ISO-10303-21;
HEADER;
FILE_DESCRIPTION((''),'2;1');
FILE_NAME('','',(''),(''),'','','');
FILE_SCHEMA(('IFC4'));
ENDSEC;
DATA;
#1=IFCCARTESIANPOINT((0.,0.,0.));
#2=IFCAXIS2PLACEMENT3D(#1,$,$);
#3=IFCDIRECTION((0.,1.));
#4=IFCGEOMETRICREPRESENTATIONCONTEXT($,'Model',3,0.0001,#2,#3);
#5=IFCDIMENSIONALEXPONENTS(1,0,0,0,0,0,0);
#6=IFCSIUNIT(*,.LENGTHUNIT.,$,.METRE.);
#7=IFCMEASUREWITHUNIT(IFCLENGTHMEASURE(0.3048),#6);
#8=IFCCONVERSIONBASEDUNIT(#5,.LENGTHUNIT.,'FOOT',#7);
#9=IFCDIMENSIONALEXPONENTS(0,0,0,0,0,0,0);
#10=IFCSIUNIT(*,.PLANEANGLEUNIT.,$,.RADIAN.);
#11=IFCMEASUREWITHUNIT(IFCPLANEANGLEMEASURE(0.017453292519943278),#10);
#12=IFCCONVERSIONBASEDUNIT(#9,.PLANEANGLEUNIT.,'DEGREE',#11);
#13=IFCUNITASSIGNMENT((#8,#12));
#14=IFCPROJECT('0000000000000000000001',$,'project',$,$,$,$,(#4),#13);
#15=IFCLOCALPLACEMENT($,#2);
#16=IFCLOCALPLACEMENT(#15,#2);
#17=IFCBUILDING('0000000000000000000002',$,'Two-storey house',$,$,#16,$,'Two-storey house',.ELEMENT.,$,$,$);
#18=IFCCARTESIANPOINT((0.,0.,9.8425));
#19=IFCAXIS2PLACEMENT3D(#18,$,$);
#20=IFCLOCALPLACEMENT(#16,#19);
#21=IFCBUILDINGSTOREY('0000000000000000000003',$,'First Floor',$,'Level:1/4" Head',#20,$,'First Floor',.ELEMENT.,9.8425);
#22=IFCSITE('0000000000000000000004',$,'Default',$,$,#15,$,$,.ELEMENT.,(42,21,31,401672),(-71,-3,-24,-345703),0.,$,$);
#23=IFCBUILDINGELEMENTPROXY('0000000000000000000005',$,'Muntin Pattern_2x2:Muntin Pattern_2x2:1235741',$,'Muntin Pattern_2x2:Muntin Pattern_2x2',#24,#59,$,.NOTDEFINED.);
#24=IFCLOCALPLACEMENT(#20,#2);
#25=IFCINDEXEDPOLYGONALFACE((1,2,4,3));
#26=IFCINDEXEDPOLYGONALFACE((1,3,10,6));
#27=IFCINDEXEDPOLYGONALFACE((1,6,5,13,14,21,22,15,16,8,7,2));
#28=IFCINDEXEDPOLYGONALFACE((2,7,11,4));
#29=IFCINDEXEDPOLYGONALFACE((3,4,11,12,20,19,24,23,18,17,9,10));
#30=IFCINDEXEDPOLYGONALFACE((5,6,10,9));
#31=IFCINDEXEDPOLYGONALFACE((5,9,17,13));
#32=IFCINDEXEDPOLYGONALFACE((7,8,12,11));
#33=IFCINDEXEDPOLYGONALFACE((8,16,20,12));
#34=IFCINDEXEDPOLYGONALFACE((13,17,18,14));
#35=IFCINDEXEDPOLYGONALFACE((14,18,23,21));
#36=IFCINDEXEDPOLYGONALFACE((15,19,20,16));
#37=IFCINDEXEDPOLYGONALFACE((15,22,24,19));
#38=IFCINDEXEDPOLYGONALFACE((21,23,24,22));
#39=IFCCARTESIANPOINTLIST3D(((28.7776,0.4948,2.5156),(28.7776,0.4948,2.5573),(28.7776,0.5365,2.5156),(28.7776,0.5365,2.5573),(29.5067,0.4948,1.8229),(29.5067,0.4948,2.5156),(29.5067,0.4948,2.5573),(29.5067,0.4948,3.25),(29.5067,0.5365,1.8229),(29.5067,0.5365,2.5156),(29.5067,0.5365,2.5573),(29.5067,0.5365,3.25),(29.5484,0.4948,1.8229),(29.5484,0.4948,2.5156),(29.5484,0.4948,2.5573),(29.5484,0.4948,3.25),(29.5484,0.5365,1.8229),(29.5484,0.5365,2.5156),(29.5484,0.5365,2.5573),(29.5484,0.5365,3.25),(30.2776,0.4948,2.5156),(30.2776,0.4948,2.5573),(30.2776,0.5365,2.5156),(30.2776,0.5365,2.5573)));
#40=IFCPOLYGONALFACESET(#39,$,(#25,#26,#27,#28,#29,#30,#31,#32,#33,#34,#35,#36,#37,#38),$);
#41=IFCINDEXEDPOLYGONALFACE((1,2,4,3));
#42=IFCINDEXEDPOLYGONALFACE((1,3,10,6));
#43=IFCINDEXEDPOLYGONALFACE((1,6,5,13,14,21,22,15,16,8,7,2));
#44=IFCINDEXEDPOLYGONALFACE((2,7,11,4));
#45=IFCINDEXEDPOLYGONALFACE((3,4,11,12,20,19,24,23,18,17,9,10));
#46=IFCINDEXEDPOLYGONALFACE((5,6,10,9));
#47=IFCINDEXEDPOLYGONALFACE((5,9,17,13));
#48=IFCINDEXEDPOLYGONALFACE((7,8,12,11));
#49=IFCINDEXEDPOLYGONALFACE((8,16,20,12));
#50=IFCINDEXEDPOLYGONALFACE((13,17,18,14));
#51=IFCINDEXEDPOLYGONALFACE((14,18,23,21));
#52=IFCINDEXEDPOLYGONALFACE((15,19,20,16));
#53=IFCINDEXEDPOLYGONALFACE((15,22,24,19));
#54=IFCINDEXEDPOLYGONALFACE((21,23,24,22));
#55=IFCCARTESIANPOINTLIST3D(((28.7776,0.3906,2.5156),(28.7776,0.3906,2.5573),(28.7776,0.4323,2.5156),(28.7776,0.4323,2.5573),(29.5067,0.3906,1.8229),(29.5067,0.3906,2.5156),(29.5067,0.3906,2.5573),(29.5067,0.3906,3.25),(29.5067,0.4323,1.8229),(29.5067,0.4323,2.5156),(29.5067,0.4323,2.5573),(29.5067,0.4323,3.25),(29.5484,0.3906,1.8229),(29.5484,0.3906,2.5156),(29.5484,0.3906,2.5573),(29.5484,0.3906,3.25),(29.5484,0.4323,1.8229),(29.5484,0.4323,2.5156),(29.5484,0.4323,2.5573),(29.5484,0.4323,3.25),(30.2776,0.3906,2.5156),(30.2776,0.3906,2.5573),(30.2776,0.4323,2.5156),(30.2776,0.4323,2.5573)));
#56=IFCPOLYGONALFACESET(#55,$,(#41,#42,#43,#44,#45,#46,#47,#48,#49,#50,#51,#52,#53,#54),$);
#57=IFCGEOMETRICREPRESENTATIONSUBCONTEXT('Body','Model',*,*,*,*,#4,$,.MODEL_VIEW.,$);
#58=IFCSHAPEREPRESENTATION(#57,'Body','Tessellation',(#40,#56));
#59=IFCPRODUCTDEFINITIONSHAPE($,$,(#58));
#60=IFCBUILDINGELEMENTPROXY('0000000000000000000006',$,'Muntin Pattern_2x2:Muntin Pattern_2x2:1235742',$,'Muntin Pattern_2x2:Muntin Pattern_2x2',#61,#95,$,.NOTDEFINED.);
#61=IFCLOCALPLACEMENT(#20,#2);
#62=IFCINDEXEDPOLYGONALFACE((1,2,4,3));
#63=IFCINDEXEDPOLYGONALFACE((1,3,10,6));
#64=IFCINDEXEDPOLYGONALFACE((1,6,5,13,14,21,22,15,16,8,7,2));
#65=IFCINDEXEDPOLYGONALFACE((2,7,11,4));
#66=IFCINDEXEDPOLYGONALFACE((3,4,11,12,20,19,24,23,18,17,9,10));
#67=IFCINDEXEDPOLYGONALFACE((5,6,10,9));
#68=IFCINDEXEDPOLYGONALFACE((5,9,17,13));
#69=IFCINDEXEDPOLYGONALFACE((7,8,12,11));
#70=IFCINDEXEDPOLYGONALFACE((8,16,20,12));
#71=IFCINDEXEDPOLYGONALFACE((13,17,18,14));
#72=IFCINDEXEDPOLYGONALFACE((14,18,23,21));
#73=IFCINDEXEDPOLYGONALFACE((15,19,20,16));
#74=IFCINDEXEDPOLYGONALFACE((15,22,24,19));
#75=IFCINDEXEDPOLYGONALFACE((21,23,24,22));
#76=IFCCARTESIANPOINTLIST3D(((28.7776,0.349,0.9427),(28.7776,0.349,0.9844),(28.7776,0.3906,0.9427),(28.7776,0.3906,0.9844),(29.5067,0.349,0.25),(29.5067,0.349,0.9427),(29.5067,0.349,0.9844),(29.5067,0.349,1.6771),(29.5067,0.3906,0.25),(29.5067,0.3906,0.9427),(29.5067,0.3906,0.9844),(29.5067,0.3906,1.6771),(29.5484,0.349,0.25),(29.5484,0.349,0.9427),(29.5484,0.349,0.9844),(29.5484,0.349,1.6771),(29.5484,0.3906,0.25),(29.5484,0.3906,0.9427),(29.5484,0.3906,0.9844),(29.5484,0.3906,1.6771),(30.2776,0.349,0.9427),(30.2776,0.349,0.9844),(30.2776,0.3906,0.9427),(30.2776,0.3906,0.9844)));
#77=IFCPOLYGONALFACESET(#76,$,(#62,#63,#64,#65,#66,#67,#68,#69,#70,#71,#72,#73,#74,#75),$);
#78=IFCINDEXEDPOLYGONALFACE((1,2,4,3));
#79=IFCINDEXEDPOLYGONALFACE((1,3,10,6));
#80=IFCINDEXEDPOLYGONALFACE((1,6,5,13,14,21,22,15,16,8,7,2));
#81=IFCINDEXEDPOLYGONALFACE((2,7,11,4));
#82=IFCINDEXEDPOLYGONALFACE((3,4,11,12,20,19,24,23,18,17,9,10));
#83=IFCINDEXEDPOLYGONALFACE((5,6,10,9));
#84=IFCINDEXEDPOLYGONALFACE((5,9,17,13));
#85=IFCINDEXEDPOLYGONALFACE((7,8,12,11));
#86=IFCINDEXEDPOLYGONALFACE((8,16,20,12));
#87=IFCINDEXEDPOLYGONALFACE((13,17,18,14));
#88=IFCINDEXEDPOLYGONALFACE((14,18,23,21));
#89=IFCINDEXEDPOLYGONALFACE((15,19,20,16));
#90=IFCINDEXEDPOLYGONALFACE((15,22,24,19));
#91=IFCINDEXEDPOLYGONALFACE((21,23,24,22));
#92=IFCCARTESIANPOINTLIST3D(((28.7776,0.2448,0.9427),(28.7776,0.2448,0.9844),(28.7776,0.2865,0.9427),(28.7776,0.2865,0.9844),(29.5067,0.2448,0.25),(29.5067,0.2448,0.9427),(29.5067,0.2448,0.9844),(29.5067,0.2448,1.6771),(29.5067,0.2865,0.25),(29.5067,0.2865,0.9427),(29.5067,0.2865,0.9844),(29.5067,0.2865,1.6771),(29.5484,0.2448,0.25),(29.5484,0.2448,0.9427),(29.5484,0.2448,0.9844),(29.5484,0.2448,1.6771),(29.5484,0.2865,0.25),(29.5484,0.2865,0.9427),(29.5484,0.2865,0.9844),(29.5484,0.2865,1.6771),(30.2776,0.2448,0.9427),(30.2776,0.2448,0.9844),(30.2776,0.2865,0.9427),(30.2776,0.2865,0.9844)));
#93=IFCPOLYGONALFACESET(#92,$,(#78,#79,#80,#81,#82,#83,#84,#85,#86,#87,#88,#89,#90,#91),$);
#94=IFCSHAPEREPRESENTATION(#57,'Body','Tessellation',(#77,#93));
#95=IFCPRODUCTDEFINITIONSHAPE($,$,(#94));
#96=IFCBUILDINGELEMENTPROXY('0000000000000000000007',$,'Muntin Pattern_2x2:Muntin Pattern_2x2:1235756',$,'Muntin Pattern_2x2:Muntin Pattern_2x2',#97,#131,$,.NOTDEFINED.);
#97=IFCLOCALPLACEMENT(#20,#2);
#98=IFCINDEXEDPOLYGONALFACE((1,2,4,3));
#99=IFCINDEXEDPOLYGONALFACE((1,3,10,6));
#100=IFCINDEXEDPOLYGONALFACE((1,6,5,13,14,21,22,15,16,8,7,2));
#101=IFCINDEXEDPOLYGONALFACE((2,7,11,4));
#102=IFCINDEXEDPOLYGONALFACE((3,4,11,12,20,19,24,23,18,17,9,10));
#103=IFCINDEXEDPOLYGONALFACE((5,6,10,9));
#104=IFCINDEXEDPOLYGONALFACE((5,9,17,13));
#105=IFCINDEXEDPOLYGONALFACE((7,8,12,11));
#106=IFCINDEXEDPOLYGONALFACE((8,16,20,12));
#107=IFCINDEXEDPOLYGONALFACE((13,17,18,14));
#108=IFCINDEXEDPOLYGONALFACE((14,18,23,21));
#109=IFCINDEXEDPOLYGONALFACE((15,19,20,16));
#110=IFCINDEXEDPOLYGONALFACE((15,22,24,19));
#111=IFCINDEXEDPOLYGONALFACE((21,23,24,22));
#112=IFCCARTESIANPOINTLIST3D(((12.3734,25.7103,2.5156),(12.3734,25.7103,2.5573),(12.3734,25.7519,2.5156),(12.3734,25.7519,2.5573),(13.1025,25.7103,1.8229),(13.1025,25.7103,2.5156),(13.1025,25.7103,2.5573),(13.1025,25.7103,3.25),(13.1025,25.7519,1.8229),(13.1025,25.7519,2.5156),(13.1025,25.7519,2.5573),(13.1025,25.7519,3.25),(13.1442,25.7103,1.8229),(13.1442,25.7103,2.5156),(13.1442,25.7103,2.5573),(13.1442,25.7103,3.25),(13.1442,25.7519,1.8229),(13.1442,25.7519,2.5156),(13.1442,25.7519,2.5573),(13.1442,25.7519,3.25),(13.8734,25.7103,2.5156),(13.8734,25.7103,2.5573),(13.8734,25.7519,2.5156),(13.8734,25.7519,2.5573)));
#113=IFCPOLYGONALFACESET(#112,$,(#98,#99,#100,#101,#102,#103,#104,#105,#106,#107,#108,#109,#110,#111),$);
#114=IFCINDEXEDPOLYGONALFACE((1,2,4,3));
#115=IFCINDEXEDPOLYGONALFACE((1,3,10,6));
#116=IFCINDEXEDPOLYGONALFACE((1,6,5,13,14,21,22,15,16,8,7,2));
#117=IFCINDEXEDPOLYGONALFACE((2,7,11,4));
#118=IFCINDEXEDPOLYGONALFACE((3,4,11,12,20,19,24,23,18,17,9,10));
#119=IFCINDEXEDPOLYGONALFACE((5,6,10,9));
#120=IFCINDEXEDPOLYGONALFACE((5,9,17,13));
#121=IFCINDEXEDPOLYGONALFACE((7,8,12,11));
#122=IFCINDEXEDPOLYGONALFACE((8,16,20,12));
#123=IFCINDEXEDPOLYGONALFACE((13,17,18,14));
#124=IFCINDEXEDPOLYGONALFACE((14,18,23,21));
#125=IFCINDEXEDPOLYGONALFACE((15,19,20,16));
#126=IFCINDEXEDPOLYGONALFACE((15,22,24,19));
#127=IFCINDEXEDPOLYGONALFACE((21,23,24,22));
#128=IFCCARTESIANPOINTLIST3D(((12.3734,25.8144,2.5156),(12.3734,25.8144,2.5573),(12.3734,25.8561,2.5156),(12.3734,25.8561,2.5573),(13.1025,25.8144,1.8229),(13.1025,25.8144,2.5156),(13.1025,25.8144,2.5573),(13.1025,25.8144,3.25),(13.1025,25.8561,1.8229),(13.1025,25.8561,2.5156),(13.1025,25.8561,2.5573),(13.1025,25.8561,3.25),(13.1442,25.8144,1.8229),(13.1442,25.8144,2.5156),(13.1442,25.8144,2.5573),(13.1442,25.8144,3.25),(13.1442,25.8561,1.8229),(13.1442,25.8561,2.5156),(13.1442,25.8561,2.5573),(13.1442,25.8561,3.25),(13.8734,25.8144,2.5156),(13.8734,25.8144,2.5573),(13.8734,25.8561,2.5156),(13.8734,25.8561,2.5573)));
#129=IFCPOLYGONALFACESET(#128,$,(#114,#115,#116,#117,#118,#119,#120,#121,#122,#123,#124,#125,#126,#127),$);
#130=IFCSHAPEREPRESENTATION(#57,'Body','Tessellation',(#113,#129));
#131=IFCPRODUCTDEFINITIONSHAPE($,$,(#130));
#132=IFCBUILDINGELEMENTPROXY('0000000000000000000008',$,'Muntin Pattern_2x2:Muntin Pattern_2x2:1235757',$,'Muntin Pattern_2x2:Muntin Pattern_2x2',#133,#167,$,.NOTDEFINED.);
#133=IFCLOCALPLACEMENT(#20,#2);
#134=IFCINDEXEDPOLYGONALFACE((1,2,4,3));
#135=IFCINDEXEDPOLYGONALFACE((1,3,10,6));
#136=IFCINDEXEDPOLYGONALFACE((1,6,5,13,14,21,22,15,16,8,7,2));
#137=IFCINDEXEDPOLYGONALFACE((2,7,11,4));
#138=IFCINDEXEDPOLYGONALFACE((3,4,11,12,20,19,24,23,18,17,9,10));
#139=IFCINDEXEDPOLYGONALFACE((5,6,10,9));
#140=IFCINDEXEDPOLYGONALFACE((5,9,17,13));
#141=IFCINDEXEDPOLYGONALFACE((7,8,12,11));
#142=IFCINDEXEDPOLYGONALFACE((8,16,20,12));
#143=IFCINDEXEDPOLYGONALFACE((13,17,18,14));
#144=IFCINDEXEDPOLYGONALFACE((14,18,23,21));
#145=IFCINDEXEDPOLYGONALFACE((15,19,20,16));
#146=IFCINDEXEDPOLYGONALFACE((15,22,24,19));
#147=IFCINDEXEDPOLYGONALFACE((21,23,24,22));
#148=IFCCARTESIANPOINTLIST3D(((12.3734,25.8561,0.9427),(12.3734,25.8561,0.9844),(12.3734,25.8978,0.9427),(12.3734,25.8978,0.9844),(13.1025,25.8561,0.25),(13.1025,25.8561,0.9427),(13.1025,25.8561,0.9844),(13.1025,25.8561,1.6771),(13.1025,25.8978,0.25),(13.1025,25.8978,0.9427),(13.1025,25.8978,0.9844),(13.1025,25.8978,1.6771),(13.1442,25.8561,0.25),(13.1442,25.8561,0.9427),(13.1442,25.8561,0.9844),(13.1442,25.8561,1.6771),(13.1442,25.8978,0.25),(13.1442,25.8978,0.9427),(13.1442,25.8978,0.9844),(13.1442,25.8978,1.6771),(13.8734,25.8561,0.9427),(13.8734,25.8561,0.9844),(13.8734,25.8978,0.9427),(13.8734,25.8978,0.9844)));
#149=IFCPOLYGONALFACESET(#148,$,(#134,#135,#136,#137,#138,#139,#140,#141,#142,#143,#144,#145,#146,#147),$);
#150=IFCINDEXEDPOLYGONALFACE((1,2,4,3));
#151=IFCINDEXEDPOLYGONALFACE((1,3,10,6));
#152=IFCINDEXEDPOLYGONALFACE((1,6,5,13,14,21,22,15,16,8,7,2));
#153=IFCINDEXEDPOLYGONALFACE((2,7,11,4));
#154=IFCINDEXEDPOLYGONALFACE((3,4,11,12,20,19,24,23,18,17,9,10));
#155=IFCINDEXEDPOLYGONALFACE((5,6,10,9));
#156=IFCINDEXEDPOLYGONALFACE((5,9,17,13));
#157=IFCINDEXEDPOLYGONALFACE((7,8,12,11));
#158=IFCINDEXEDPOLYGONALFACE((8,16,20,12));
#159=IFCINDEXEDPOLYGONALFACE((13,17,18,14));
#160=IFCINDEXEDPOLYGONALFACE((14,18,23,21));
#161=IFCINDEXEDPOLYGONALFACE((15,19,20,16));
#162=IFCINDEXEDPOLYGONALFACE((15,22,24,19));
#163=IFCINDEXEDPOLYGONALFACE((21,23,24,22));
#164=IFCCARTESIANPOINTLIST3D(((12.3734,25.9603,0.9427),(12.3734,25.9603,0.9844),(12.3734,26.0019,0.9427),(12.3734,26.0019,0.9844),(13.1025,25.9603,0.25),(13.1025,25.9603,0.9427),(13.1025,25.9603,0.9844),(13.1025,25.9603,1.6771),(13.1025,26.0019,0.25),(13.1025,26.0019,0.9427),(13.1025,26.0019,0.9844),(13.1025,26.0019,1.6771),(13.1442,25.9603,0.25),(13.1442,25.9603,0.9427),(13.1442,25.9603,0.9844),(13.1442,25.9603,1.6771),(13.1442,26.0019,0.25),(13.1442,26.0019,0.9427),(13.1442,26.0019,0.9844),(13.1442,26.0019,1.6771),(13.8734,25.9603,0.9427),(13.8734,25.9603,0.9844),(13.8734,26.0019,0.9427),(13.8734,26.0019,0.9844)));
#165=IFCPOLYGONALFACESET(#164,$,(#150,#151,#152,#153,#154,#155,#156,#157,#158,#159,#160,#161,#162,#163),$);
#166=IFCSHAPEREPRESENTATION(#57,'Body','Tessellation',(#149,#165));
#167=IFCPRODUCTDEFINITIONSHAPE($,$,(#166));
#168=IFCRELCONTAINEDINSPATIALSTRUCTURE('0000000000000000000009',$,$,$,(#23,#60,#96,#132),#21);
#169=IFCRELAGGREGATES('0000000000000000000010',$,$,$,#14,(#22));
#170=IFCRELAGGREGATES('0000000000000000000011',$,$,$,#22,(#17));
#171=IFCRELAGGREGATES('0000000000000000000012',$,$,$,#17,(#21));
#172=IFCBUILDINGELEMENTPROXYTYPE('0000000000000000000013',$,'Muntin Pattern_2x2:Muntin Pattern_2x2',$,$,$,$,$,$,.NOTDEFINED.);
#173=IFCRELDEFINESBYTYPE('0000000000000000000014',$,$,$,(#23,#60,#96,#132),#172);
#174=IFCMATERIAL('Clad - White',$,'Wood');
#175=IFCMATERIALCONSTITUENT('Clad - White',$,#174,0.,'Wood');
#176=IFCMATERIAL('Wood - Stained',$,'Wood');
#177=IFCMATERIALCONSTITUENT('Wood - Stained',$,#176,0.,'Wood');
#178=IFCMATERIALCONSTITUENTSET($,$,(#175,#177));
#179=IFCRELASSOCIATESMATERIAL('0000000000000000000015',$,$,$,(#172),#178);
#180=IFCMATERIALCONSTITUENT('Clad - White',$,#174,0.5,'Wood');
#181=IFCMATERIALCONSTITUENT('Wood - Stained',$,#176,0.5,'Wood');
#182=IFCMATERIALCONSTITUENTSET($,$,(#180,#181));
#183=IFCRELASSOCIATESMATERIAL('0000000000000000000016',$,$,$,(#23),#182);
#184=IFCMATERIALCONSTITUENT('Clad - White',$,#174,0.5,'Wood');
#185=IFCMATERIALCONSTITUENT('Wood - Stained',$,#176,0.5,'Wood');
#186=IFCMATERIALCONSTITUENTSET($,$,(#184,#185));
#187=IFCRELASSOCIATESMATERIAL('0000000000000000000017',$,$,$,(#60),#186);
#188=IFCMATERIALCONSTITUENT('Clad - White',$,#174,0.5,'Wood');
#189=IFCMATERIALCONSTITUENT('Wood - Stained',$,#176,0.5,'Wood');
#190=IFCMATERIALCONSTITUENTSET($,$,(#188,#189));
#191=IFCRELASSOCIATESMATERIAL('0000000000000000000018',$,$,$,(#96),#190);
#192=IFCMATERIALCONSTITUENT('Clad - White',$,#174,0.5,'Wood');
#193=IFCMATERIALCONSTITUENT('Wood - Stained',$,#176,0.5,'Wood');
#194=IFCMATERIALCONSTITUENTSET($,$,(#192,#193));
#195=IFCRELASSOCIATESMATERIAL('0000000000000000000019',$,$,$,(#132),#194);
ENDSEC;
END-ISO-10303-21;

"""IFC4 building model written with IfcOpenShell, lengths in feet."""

from ifc_helpers import new_model, entity, si_unit, converted_unit, direction, frame, origin, place, context, subcontext, project, spatial, indexed_curve, outline, extrude, source, transform, mapped, material, constituent, constituent_set, type_object, type_shapes, element, save


model = new_model("IFC4")

# Units and contexts
model_context = context("Model", 3, precision=0.0001, world=origin(), true_north=direction((0.0, 1.0)))
body_context = subcontext(model_context, "Body", "Model", "MODEL_VIEW")
ifc_project = project(units=[converted_unit("LENGTHUNIT", "FOOT", entity("IfcLengthMeasure", 0.3048), si_unit("LENGTHUNIT", "METRE"), dimensions=[1, 0, 0, 0, 0, 0, 0]), converted_unit("PLANEANGLEUNIT", "DEGREE", entity("IfcPlaneAngleMeasure", 0.017453292519943278), si_unit("PLANEANGLEUNIT", "RADIAN"), dimensions=[0, 0, 0, 0, 0, 0, 0])], contexts=[model_context])

# Site, building, storey
site_placement = place(None, origin())
site = spatial("IfcSite", under=ifc_project, at=site_placement, Name="Default", CompositionType="ELEMENT", RefLatitude=(42, 21, 31, 401672), RefLongitude=(-71, -3, -24, -345703), RefElevation=0.0)
building_placement = place(site_placement, origin())
building = spatial("IfcBuilding", under=site, at=building_placement, Name="Two-storey house", LongName="Two-storey house", CompositionType="ELEMENT")
storey_placement = place(building_placement, frame((0.0, 0.0, 9.8425)))
storey = spatial("IfcBuildingStorey", under=building, at=storey_placement, Name="First Floor", ObjectType="Level:1/4\" Head", LongName="First Floor", CompositionType="ELEMENT", Elevation=9.8425)

# Shared definitions
ifc_material_1 = material(Name="Wood - Stained", Category="Wood")

# Building element proxies
ifc_material_2 = material(Name="Clad - White", Category="Wood")
ifc_constituent_1 = constituent(ifc_material_2, Name="Clad - White", Category="Wood", fraction=0.5)
ifc_constituent_2 = constituent(ifc_material_1, Name="Wood - Stained", Category="Wood", fraction=0.5)
ifc_constituent_set_1 = constituent_set(constituents=[ifc_constituent_1, ifc_constituent_2])
ifc_constituent_3 = constituent(ifc_material_2, Name="Clad - White", Category="Wood", fraction=0.0)
ifc_constituent_4 = constituent(ifc_material_1, Name="Wood - Stained", Category="Wood", fraction=0.0)
ifc_constituent_set_2 = constituent_set(constituents=[ifc_constituent_3, ifc_constituent_4])
building_element_proxy_type_1 = type_object("IfcBuildingElementProxyType", Name="Muntin Pattern_2x2:Muntin Pattern_2x2", PredefinedType="NOTDEFINED", material=ifc_constituent_set_2)
shared_shape_1 = source(origin(), body_context, "Body", "SweptSolid", [
    extrude(outline(indexed_curve([(0.0208, -0.0208), (0.7135, -0.0208), (0.7135, 0.0208), (0.0208, 0.0208), (0.0208, 0.75), (-0.0208, 0.75), (-0.0208, 0.0208), (-0.7135, 0.0208), (-0.7135, -0.0208), (-0.0208, -0.0208), (-0.0208, -0.75), (0.0208, -0.75), (0.0208, -0.0208)], self_intersect=False)), frame((0.0, 0.0312, 0.7135), z_axis=(0.0, 1.0, 0.0), x_axis=(0.0, 0.0, 1.0)), (0.0, 0.0, 1.0), 0.0417),
    extrude(outline(indexed_curve([(0.0208, -0.0208), (0.7135, -0.0208), (0.7135, 0.0208), (0.0208, 0.0208), (0.0208, 0.75), (-0.0208, 0.75), (-0.0208, 0.0208), (-0.7135, 0.0208), (-0.7135, -0.0208), (-0.0208, -0.0208), (-0.0208, -0.75), (0.0208, -0.75), (0.0208, -0.0208)], self_intersect=False)), frame((0.0, -0.0729, 0.7135), z_axis=(0.0, 1.0, 0.0), x_axis=(0.0, 0.0, 1.0)), (0.0, 0.0, 1.0), 0.0417),
])
type_shapes(building_element_proxy_type_1, [shared_shape_1])
proxy_1_placement = place(storey_placement, frame((29.5276, 0.4635, 1.8229)))
element("IfcBuildingElementProxy", 1, at=proxy_1_placement, inside=storey, type_object=building_element_proxy_type_1, material=ifc_constituent_set_1, Name="Muntin Pattern_2x2:Muntin Pattern_2x2:1235741", ObjectType="Muntin Pattern_2x2:Muntin Pattern_2x2", PredefinedType="NOTDEFINED", context=body_context, shape_type="MappedRepresentation", body=[
    mapped(shared_shape_1, transform((0.0, 0.0, 0.0), scale=1.0)),
])
ifc_constituent_5 = constituent(ifc_material_2, Name="Clad - White", Category="Wood", fraction=0.5)
ifc_constituent_6 = constituent(ifc_material_1, Name="Wood - Stained", Category="Wood", fraction=0.5)
ifc_constituent_set_3 = constituent_set(constituents=[ifc_constituent_5, ifc_constituent_6])
proxy_2_placement = place(storey_placement, frame((29.5276, 0.3177, 0.25)))
element("IfcBuildingElementProxy", 2, at=proxy_2_placement, inside=storey, type_object=building_element_proxy_type_1, material=ifc_constituent_set_3, Name="Muntin Pattern_2x2:Muntin Pattern_2x2:1235742", ObjectType="Muntin Pattern_2x2:Muntin Pattern_2x2", PredefinedType="NOTDEFINED", context=body_context, shape_type="MappedRepresentation", body=[
    mapped(shared_shape_1, transform((0.0, 0.0, 0.0), scale=1.0)),
])
ifc_constituent_7 = constituent(ifc_material_2, Name="Clad - White", Category="Wood", fraction=0.5)
ifc_constituent_8 = constituent(ifc_material_1, Name="Wood - Stained", Category="Wood", fraction=0.5)
ifc_constituent_set_4 = constituent_set(constituents=[ifc_constituent_7, ifc_constituent_8])
proxy_3_placement = place(storey_placement, frame((13.1234, 25.7832, 1.8229), z_axis=(0.0, 0.0, 1.0), x_axis=(-1.0, 0.0, 0.0)))
element("IfcBuildingElementProxy", 3, at=proxy_3_placement, inside=storey, type_object=building_element_proxy_type_1, material=ifc_constituent_set_4, Name="Muntin Pattern_2x2:Muntin Pattern_2x2:1235756", ObjectType="Muntin Pattern_2x2:Muntin Pattern_2x2", PredefinedType="NOTDEFINED", context=body_context, shape_type="MappedRepresentation", body=[
    mapped(shared_shape_1, transform((0.0, 0.0, 0.0), scale=1.0)),
])
ifc_constituent_9 = constituent(ifc_material_2, Name="Clad - White", Category="Wood", fraction=0.5)
ifc_constituent_10 = constituent(ifc_material_1, Name="Wood - Stained", Category="Wood", fraction=0.5)
ifc_constituent_set_5 = constituent_set(constituents=[ifc_constituent_9, ifc_constituent_10])
proxy_4_placement = place(storey_placement, frame((13.1234, 25.929, 0.25), z_axis=(0.0, 0.0, 1.0), x_axis=(-1.0, 0.0, 0.0)))
element("IfcBuildingElementProxy", 4, at=proxy_4_placement, inside=storey, type_object=building_element_proxy_type_1, material=ifc_constituent_set_5, Name="Muntin Pattern_2x2:Muntin Pattern_2x2:1235757", ObjectType="Muntin Pattern_2x2:Muntin Pattern_2x2", PredefinedType="NOTDEFINED", context=body_context, shape_type="MappedRepresentation", body=[
    mapped(shared_shape_1, transform((0.0, 0.0, 0.0), scale=1.0)),
])

save(model, "model.ifc")
